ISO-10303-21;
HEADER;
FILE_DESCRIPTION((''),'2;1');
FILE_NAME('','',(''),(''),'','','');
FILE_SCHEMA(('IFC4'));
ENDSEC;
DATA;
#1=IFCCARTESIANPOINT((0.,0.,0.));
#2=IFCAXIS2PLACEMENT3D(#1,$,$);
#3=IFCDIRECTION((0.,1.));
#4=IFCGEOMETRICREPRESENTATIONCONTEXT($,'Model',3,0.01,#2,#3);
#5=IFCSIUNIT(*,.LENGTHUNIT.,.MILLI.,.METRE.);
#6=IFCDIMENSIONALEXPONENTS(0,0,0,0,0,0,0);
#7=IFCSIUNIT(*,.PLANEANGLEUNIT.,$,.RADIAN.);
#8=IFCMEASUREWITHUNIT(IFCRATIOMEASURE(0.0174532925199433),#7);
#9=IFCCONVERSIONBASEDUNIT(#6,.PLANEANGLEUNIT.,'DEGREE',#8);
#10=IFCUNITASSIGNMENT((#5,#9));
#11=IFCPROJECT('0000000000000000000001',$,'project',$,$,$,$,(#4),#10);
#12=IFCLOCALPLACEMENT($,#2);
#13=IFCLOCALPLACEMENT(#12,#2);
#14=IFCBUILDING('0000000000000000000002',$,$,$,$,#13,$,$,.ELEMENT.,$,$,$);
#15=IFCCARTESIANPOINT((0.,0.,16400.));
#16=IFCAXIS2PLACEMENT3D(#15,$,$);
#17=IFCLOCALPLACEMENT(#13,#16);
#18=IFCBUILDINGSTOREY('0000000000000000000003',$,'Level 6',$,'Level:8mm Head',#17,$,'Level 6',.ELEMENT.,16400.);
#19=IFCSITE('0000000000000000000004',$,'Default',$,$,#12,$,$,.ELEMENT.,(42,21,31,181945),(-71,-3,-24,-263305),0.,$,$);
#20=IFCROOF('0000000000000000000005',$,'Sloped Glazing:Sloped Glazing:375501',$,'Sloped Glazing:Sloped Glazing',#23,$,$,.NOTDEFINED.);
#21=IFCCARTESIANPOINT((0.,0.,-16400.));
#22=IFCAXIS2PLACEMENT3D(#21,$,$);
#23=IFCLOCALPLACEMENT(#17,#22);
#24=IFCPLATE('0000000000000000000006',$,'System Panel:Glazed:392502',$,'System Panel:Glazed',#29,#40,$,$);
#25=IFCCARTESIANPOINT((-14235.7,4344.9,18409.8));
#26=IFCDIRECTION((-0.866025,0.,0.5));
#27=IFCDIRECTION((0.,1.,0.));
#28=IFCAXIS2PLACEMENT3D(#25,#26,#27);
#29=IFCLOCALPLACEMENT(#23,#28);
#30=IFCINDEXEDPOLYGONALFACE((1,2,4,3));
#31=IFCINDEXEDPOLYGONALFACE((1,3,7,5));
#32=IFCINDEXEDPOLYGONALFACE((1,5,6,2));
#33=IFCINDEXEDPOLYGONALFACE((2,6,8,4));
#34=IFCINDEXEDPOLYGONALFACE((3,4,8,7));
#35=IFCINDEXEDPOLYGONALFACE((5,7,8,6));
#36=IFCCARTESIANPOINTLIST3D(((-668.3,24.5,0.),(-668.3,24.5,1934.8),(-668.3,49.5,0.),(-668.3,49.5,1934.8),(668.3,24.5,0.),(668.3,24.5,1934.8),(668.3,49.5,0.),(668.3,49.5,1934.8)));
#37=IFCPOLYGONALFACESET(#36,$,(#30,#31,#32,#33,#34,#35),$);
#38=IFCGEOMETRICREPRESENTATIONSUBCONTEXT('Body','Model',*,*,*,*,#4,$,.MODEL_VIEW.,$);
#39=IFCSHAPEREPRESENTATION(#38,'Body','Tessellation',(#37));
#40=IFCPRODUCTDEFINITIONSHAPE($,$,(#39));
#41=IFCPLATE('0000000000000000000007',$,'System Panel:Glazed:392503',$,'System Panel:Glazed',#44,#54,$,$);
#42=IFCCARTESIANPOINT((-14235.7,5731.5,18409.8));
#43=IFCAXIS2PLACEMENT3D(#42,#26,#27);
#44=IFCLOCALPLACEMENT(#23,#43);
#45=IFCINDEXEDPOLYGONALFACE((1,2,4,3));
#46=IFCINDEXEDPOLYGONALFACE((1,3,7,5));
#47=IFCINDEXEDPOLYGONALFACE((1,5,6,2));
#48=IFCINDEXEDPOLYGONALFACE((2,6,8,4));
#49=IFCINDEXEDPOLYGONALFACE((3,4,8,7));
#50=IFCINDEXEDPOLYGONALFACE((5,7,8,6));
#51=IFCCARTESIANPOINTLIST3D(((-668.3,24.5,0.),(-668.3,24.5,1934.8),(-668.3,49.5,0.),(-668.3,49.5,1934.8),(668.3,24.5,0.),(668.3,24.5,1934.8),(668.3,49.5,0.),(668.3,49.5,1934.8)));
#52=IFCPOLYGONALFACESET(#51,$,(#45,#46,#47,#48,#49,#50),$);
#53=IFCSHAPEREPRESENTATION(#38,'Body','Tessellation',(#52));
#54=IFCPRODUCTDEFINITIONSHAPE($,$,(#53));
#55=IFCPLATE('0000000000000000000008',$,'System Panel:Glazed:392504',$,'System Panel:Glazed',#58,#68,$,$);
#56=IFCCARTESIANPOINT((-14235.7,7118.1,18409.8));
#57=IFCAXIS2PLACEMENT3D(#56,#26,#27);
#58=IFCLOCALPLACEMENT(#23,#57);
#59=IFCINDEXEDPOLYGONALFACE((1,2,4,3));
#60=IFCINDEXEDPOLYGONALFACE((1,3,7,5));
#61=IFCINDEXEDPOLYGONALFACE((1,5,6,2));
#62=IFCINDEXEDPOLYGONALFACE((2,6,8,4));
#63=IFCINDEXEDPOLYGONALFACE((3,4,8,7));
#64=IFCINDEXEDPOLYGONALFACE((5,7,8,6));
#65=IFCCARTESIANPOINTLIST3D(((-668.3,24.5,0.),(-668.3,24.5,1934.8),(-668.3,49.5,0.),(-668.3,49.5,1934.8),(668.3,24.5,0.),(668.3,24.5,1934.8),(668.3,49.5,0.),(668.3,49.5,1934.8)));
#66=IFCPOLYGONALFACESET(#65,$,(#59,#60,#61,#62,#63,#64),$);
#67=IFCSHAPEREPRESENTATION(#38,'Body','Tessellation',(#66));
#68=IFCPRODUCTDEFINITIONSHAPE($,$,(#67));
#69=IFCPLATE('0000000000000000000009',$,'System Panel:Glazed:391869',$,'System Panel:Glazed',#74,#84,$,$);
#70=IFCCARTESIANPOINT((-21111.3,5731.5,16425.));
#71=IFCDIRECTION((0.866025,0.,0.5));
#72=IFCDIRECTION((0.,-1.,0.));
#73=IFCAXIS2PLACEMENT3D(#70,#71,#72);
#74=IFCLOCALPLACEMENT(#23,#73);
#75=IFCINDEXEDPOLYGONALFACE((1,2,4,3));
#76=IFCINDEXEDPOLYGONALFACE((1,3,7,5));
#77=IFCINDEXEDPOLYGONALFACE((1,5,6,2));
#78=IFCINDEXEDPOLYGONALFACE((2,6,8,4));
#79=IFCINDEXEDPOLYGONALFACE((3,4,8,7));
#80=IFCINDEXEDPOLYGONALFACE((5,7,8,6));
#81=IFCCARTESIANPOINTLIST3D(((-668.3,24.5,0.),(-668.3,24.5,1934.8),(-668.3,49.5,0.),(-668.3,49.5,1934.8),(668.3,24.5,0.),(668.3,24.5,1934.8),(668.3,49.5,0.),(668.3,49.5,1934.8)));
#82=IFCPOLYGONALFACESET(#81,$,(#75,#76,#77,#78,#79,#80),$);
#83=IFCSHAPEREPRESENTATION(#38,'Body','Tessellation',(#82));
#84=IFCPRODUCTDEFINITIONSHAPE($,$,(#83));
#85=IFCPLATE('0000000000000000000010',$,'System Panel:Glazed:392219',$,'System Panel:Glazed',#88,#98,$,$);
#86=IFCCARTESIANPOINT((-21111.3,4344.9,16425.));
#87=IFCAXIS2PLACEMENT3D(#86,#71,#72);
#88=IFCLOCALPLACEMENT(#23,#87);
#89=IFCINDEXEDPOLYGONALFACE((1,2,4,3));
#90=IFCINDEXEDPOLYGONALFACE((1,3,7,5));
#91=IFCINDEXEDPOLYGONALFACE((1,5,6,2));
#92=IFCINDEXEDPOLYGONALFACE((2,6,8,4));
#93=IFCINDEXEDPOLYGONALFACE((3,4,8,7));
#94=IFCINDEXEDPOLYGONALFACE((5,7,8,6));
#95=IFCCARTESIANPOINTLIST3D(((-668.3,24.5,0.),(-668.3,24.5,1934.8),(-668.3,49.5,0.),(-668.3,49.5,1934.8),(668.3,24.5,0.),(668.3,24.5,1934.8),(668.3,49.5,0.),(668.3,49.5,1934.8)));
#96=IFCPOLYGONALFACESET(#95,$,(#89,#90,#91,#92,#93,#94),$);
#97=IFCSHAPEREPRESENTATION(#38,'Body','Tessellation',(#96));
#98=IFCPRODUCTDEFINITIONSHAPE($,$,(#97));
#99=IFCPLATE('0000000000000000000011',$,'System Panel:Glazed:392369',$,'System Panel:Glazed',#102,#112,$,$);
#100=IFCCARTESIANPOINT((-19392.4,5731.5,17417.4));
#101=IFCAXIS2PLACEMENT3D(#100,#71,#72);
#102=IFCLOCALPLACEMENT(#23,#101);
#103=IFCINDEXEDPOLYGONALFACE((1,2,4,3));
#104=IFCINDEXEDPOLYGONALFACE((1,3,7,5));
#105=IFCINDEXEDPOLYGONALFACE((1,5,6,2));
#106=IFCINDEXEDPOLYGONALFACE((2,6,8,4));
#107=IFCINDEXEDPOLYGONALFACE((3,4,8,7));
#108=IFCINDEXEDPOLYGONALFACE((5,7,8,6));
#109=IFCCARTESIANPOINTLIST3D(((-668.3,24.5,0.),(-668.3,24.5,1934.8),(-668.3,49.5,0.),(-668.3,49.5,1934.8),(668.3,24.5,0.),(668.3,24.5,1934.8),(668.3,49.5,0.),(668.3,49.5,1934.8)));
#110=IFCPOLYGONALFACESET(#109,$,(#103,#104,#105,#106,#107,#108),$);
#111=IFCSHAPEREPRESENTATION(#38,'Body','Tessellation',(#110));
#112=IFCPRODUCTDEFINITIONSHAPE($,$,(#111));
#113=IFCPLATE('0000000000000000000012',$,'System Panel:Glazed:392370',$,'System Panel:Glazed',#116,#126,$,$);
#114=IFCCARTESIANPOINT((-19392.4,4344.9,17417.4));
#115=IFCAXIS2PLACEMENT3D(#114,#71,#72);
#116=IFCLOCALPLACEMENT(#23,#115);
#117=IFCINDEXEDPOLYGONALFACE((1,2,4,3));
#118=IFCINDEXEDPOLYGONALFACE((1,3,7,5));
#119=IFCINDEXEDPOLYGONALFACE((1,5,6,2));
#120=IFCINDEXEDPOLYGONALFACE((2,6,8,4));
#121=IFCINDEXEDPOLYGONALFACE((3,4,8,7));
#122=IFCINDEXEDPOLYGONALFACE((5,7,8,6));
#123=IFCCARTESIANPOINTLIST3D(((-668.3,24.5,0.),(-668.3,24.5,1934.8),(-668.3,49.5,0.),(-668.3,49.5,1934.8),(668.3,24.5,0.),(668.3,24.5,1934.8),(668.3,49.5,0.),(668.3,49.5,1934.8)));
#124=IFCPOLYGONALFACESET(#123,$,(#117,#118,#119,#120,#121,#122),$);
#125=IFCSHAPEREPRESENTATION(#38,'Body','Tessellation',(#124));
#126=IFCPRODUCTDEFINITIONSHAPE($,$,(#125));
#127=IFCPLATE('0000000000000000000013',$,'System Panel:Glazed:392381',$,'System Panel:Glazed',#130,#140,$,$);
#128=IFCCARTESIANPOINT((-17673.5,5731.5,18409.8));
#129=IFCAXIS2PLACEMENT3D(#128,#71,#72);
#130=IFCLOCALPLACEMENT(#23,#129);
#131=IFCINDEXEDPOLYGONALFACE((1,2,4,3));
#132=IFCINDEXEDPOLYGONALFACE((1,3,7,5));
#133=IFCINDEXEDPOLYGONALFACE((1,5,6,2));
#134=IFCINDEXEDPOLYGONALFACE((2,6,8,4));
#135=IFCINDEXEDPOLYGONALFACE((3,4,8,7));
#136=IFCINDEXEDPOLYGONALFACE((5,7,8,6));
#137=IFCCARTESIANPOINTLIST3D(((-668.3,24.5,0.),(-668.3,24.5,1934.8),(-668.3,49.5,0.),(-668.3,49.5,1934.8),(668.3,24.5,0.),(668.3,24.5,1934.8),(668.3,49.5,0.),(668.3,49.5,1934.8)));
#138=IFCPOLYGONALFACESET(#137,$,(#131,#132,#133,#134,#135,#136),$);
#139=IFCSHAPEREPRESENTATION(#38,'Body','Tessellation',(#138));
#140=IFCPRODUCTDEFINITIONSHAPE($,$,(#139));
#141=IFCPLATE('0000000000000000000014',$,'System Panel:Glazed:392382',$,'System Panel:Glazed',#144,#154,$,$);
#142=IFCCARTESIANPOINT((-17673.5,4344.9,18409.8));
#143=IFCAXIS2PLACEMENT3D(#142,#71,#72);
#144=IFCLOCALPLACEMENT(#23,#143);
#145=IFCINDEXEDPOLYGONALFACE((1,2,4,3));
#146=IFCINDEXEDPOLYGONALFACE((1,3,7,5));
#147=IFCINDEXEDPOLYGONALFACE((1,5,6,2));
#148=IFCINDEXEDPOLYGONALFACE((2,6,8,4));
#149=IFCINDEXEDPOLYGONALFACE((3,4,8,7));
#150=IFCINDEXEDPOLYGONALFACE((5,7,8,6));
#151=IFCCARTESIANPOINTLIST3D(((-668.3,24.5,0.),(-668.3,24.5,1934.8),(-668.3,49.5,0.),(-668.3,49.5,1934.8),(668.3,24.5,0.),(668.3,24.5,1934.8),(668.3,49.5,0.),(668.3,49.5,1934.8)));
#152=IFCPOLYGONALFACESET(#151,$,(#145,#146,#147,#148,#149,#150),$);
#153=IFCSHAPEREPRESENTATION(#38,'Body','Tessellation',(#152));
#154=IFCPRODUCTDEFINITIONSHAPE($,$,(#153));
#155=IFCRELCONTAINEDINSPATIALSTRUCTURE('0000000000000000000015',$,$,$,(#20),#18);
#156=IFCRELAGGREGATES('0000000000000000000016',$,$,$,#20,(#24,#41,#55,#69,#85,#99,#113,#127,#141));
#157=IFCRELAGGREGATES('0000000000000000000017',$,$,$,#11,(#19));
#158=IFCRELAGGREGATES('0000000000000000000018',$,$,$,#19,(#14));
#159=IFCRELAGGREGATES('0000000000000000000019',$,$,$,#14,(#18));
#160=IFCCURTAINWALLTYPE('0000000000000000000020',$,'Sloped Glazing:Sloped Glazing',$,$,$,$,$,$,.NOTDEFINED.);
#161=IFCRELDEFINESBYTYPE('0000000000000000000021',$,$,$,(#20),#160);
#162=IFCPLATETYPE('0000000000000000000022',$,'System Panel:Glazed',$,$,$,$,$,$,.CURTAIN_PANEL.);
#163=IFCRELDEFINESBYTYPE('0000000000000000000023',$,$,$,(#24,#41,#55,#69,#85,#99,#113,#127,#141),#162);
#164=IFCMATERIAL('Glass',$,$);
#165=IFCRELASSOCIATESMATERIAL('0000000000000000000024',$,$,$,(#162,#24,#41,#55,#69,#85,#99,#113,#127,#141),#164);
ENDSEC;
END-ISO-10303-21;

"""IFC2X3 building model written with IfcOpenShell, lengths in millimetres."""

from ifc_helpers import new_model, entity, si_unit, converted_unit, direction, frame, origin, origin_2d_with_axis, place, context, subcontext, project, spatial, rectangle, extrude, source, transform, mapped, material, type_object, type_shapes, element, aggregate, save


model = new_model("IFC2X3")

# Units and contexts
model_context = context("Model", 3, precision=0.01, world=origin(), true_north=direction((0.0, 1.0)))
body_context = subcontext(model_context, "Body", "Model", "MODEL_VIEW")
ifc_project = project(units=[si_unit("LENGTHUNIT", "METRE", prefix="MILLI"), converted_unit("PLANEANGLEUNIT", "DEGREE", entity("IfcRatioMeasure", 0.0174532925199433), si_unit("PLANEANGLEUNIT", "RADIAN"), dimensions=[0, 0, 0, 0, 0, 0, 0])], contexts=[model_context])

# Site, building, storey
site_placement = place(None, frame((0.0, 0.0, 0.0)))
site = spatial("IfcSite", under=ifc_project, at=site_placement, Name="Default", CompositionType="ELEMENT", RefLatitude=(42, 21, 31, 181945), RefLongitude=(-71, -3, -24, -263305), RefElevation=0.0)
building_placement = place(site_placement, origin())
building = spatial("IfcBuilding", under=site, at=building_placement, CompositionType="ELEMENT")
storey_placement = place(building_placement, frame((0.0, 0.0, 16400.0)))
storey = spatial("IfcBuildingStorey", under=building, at=storey_placement, Name="Level 6", ObjectType="Level:8mm Head", LongName="Level 6", CompositionType="ELEMENT", Elevation=16400.0)

# Roof, plates
curtain_wall_type = type_object("IfcCurtainWallType", Name="Sloped Glazing:Sloped Glazing", PredefinedType="NOTDEFINED")
roof_placement = place(storey_placement, frame((0.0, 0.0, -16400.0)))
roof = element("IfcRoof", 1, at=roof_placement, inside=storey, type_object=curtain_wall_type, Name="Sloped Glazing:Sloped Glazing:375501", ObjectType="Sloped Glazing:Sloped Glazing", ShapeType="NOTDEFINED")
ifc_material_1 = material(Name="Glass")
plate_type = type_object("IfcPlateType", Name="System Panel:Glazed", PredefinedType="CURTAIN_PANEL", material=ifc_material_1)
shared_shape_1 = source(origin(), body_context, "Body", "SweptSolid", [
    extrude(rectangle(XDim=25.0, YDim=1336.6, at=origin_2d_with_axis()), frame((0.0, 37.0, 0.0), z_axis=(0.0, 0.0, 1.0), x_axis=(0.0, 1.0, 0.0)), (0.0, 0.0, 1.0), 1934.8),
])
type_shapes(plate_type, [shared_shape_1])
plate_1_placement = place(roof_placement, frame((-14235.7, 4344.9, 18409.8), z_axis=(-0.866025, 0.0, 0.5), x_axis=(0.0, 1.0, 0.0)))
plate_1 = element("IfcPlate", 2, at=plate_1_placement, type_object=plate_type, material=ifc_material_1, Name="System Panel:Glazed:392502", ObjectType="System Panel:Glazed", context=body_context, shape_type="MappedRepresentation", body=[
    mapped(shared_shape_1, transform((0.0, 0.0, 0.0), scale=1.0)),
])
plate_2_placement = place(roof_placement, frame((-14235.7, 5731.5, 18409.8), z_axis=(-0.866025, 0.0, 0.5), x_axis=(0.0, 1.0, 0.0)))
plate_2 = element("IfcPlate", 3, at=plate_2_placement, type_object=plate_type, material=ifc_material_1, Name="System Panel:Glazed:392503", ObjectType="System Panel:Glazed", context=body_context, shape_type="MappedRepresentation", body=[
    mapped(shared_shape_1, transform((0.0, 0.0, 0.0), scale=1.0)),
])
plate_3_placement = place(roof_placement, frame((-14235.7, 7118.1, 18409.8), z_axis=(-0.866025, 0.0, 0.5), x_axis=(0.0, 1.0, 0.0)))
plate_3 = element("IfcPlate", 4, at=plate_3_placement, type_object=plate_type, material=ifc_material_1, Name="System Panel:Glazed:392504", ObjectType="System Panel:Glazed", context=body_context, shape_type="MappedRepresentation", body=[
    mapped(shared_shape_1, transform((0.0, 0.0, 0.0), scale=1.0)),
])
plate_4_placement = place(roof_placement, frame((-21111.3, 5731.5, 16425.0), z_axis=(0.866025, 0.0, 0.5), x_axis=(0.0, -1.0, 0.0)))
plate_4 = element("IfcPlate", 5, at=plate_4_placement, type_object=plate_type, material=ifc_material_1, Name="System Panel:Glazed:391869", ObjectType="System Panel:Glazed", context=body_context, shape_type="MappedRepresentation", body=[
    mapped(shared_shape_1, transform((0.0, 0.0, 0.0), scale=1.0)),
])
plate_5_placement = place(roof_placement, frame((-21111.3, 4344.9, 16425.0), z_axis=(0.866025, 0.0, 0.5), x_axis=(0.0, -1.0, 0.0)))
plate_5 = element("IfcPlate", 6, at=plate_5_placement, type_object=plate_type, material=ifc_material_1, Name="System Panel:Glazed:392219", ObjectType="System Panel:Glazed", context=body_context, shape_type="MappedRepresentation", body=[
    mapped(shared_shape_1, transform((0.0, 0.0, 0.0), scale=1.0)),
])
plate_6_placement = place(roof_placement, frame((-19392.4, 5731.5, 17417.4), z_axis=(0.866025, 0.0, 0.5), x_axis=(0.0, -1.0, 0.0)))
plate_6 = element("IfcPlate", 7, at=plate_6_placement, type_object=plate_type, material=ifc_material_1, Name="System Panel:Glazed:392369", ObjectType="System Panel:Glazed", context=body_context, shape_type="MappedRepresentation", body=[
    mapped(shared_shape_1, transform((0.0, 0.0, 0.0), scale=1.0)),
])
plate_7_placement = place(roof_placement, frame((-19392.4, 4344.9, 17417.4), z_axis=(0.866025, 0.0, 0.5), x_axis=(0.0, -1.0, 0.0)))
plate_7 = element("IfcPlate", 8, at=plate_7_placement, type_object=plate_type, material=ifc_material_1, Name="System Panel:Glazed:392370", ObjectType="System Panel:Glazed", context=body_context, shape_type="MappedRepresentation", body=[
    mapped(shared_shape_1, transform((0.0, 0.0, 0.0), scale=1.0)),
])
plate_8_placement = place(roof_placement, frame((-17673.5, 5731.5, 18409.8), z_axis=(0.866025, 0.0, 0.5), x_axis=(0.0, -1.0, 0.0)))
plate_8 = element("IfcPlate", 9, at=plate_8_placement, type_object=plate_type, material=ifc_material_1, Name="System Panel:Glazed:392381", ObjectType="System Panel:Glazed", context=body_context, shape_type="MappedRepresentation", body=[
    mapped(shared_shape_1, transform((0.0, 0.0, 0.0), scale=1.0)),
])
plate_9_placement = place(roof_placement, frame((-17673.5, 4344.9, 18409.8), z_axis=(0.866025, 0.0, 0.5), x_axis=(0.0, -1.0, 0.0)))
plate_9 = element("IfcPlate", 10, at=plate_9_placement, type_object=plate_type, material=ifc_material_1, Name="System Panel:Glazed:392382", ObjectType="System Panel:Glazed", context=body_context, shape_type="MappedRepresentation", body=[
    mapped(shared_shape_1, transform((0.0, 0.0, 0.0), scale=1.0)),
])
aggregate(roof, [plate_1, plate_2, plate_3, plate_4, plate_5, plate_6, plate_7, plate_8, plate_9])

save(model, "model.ifc")
